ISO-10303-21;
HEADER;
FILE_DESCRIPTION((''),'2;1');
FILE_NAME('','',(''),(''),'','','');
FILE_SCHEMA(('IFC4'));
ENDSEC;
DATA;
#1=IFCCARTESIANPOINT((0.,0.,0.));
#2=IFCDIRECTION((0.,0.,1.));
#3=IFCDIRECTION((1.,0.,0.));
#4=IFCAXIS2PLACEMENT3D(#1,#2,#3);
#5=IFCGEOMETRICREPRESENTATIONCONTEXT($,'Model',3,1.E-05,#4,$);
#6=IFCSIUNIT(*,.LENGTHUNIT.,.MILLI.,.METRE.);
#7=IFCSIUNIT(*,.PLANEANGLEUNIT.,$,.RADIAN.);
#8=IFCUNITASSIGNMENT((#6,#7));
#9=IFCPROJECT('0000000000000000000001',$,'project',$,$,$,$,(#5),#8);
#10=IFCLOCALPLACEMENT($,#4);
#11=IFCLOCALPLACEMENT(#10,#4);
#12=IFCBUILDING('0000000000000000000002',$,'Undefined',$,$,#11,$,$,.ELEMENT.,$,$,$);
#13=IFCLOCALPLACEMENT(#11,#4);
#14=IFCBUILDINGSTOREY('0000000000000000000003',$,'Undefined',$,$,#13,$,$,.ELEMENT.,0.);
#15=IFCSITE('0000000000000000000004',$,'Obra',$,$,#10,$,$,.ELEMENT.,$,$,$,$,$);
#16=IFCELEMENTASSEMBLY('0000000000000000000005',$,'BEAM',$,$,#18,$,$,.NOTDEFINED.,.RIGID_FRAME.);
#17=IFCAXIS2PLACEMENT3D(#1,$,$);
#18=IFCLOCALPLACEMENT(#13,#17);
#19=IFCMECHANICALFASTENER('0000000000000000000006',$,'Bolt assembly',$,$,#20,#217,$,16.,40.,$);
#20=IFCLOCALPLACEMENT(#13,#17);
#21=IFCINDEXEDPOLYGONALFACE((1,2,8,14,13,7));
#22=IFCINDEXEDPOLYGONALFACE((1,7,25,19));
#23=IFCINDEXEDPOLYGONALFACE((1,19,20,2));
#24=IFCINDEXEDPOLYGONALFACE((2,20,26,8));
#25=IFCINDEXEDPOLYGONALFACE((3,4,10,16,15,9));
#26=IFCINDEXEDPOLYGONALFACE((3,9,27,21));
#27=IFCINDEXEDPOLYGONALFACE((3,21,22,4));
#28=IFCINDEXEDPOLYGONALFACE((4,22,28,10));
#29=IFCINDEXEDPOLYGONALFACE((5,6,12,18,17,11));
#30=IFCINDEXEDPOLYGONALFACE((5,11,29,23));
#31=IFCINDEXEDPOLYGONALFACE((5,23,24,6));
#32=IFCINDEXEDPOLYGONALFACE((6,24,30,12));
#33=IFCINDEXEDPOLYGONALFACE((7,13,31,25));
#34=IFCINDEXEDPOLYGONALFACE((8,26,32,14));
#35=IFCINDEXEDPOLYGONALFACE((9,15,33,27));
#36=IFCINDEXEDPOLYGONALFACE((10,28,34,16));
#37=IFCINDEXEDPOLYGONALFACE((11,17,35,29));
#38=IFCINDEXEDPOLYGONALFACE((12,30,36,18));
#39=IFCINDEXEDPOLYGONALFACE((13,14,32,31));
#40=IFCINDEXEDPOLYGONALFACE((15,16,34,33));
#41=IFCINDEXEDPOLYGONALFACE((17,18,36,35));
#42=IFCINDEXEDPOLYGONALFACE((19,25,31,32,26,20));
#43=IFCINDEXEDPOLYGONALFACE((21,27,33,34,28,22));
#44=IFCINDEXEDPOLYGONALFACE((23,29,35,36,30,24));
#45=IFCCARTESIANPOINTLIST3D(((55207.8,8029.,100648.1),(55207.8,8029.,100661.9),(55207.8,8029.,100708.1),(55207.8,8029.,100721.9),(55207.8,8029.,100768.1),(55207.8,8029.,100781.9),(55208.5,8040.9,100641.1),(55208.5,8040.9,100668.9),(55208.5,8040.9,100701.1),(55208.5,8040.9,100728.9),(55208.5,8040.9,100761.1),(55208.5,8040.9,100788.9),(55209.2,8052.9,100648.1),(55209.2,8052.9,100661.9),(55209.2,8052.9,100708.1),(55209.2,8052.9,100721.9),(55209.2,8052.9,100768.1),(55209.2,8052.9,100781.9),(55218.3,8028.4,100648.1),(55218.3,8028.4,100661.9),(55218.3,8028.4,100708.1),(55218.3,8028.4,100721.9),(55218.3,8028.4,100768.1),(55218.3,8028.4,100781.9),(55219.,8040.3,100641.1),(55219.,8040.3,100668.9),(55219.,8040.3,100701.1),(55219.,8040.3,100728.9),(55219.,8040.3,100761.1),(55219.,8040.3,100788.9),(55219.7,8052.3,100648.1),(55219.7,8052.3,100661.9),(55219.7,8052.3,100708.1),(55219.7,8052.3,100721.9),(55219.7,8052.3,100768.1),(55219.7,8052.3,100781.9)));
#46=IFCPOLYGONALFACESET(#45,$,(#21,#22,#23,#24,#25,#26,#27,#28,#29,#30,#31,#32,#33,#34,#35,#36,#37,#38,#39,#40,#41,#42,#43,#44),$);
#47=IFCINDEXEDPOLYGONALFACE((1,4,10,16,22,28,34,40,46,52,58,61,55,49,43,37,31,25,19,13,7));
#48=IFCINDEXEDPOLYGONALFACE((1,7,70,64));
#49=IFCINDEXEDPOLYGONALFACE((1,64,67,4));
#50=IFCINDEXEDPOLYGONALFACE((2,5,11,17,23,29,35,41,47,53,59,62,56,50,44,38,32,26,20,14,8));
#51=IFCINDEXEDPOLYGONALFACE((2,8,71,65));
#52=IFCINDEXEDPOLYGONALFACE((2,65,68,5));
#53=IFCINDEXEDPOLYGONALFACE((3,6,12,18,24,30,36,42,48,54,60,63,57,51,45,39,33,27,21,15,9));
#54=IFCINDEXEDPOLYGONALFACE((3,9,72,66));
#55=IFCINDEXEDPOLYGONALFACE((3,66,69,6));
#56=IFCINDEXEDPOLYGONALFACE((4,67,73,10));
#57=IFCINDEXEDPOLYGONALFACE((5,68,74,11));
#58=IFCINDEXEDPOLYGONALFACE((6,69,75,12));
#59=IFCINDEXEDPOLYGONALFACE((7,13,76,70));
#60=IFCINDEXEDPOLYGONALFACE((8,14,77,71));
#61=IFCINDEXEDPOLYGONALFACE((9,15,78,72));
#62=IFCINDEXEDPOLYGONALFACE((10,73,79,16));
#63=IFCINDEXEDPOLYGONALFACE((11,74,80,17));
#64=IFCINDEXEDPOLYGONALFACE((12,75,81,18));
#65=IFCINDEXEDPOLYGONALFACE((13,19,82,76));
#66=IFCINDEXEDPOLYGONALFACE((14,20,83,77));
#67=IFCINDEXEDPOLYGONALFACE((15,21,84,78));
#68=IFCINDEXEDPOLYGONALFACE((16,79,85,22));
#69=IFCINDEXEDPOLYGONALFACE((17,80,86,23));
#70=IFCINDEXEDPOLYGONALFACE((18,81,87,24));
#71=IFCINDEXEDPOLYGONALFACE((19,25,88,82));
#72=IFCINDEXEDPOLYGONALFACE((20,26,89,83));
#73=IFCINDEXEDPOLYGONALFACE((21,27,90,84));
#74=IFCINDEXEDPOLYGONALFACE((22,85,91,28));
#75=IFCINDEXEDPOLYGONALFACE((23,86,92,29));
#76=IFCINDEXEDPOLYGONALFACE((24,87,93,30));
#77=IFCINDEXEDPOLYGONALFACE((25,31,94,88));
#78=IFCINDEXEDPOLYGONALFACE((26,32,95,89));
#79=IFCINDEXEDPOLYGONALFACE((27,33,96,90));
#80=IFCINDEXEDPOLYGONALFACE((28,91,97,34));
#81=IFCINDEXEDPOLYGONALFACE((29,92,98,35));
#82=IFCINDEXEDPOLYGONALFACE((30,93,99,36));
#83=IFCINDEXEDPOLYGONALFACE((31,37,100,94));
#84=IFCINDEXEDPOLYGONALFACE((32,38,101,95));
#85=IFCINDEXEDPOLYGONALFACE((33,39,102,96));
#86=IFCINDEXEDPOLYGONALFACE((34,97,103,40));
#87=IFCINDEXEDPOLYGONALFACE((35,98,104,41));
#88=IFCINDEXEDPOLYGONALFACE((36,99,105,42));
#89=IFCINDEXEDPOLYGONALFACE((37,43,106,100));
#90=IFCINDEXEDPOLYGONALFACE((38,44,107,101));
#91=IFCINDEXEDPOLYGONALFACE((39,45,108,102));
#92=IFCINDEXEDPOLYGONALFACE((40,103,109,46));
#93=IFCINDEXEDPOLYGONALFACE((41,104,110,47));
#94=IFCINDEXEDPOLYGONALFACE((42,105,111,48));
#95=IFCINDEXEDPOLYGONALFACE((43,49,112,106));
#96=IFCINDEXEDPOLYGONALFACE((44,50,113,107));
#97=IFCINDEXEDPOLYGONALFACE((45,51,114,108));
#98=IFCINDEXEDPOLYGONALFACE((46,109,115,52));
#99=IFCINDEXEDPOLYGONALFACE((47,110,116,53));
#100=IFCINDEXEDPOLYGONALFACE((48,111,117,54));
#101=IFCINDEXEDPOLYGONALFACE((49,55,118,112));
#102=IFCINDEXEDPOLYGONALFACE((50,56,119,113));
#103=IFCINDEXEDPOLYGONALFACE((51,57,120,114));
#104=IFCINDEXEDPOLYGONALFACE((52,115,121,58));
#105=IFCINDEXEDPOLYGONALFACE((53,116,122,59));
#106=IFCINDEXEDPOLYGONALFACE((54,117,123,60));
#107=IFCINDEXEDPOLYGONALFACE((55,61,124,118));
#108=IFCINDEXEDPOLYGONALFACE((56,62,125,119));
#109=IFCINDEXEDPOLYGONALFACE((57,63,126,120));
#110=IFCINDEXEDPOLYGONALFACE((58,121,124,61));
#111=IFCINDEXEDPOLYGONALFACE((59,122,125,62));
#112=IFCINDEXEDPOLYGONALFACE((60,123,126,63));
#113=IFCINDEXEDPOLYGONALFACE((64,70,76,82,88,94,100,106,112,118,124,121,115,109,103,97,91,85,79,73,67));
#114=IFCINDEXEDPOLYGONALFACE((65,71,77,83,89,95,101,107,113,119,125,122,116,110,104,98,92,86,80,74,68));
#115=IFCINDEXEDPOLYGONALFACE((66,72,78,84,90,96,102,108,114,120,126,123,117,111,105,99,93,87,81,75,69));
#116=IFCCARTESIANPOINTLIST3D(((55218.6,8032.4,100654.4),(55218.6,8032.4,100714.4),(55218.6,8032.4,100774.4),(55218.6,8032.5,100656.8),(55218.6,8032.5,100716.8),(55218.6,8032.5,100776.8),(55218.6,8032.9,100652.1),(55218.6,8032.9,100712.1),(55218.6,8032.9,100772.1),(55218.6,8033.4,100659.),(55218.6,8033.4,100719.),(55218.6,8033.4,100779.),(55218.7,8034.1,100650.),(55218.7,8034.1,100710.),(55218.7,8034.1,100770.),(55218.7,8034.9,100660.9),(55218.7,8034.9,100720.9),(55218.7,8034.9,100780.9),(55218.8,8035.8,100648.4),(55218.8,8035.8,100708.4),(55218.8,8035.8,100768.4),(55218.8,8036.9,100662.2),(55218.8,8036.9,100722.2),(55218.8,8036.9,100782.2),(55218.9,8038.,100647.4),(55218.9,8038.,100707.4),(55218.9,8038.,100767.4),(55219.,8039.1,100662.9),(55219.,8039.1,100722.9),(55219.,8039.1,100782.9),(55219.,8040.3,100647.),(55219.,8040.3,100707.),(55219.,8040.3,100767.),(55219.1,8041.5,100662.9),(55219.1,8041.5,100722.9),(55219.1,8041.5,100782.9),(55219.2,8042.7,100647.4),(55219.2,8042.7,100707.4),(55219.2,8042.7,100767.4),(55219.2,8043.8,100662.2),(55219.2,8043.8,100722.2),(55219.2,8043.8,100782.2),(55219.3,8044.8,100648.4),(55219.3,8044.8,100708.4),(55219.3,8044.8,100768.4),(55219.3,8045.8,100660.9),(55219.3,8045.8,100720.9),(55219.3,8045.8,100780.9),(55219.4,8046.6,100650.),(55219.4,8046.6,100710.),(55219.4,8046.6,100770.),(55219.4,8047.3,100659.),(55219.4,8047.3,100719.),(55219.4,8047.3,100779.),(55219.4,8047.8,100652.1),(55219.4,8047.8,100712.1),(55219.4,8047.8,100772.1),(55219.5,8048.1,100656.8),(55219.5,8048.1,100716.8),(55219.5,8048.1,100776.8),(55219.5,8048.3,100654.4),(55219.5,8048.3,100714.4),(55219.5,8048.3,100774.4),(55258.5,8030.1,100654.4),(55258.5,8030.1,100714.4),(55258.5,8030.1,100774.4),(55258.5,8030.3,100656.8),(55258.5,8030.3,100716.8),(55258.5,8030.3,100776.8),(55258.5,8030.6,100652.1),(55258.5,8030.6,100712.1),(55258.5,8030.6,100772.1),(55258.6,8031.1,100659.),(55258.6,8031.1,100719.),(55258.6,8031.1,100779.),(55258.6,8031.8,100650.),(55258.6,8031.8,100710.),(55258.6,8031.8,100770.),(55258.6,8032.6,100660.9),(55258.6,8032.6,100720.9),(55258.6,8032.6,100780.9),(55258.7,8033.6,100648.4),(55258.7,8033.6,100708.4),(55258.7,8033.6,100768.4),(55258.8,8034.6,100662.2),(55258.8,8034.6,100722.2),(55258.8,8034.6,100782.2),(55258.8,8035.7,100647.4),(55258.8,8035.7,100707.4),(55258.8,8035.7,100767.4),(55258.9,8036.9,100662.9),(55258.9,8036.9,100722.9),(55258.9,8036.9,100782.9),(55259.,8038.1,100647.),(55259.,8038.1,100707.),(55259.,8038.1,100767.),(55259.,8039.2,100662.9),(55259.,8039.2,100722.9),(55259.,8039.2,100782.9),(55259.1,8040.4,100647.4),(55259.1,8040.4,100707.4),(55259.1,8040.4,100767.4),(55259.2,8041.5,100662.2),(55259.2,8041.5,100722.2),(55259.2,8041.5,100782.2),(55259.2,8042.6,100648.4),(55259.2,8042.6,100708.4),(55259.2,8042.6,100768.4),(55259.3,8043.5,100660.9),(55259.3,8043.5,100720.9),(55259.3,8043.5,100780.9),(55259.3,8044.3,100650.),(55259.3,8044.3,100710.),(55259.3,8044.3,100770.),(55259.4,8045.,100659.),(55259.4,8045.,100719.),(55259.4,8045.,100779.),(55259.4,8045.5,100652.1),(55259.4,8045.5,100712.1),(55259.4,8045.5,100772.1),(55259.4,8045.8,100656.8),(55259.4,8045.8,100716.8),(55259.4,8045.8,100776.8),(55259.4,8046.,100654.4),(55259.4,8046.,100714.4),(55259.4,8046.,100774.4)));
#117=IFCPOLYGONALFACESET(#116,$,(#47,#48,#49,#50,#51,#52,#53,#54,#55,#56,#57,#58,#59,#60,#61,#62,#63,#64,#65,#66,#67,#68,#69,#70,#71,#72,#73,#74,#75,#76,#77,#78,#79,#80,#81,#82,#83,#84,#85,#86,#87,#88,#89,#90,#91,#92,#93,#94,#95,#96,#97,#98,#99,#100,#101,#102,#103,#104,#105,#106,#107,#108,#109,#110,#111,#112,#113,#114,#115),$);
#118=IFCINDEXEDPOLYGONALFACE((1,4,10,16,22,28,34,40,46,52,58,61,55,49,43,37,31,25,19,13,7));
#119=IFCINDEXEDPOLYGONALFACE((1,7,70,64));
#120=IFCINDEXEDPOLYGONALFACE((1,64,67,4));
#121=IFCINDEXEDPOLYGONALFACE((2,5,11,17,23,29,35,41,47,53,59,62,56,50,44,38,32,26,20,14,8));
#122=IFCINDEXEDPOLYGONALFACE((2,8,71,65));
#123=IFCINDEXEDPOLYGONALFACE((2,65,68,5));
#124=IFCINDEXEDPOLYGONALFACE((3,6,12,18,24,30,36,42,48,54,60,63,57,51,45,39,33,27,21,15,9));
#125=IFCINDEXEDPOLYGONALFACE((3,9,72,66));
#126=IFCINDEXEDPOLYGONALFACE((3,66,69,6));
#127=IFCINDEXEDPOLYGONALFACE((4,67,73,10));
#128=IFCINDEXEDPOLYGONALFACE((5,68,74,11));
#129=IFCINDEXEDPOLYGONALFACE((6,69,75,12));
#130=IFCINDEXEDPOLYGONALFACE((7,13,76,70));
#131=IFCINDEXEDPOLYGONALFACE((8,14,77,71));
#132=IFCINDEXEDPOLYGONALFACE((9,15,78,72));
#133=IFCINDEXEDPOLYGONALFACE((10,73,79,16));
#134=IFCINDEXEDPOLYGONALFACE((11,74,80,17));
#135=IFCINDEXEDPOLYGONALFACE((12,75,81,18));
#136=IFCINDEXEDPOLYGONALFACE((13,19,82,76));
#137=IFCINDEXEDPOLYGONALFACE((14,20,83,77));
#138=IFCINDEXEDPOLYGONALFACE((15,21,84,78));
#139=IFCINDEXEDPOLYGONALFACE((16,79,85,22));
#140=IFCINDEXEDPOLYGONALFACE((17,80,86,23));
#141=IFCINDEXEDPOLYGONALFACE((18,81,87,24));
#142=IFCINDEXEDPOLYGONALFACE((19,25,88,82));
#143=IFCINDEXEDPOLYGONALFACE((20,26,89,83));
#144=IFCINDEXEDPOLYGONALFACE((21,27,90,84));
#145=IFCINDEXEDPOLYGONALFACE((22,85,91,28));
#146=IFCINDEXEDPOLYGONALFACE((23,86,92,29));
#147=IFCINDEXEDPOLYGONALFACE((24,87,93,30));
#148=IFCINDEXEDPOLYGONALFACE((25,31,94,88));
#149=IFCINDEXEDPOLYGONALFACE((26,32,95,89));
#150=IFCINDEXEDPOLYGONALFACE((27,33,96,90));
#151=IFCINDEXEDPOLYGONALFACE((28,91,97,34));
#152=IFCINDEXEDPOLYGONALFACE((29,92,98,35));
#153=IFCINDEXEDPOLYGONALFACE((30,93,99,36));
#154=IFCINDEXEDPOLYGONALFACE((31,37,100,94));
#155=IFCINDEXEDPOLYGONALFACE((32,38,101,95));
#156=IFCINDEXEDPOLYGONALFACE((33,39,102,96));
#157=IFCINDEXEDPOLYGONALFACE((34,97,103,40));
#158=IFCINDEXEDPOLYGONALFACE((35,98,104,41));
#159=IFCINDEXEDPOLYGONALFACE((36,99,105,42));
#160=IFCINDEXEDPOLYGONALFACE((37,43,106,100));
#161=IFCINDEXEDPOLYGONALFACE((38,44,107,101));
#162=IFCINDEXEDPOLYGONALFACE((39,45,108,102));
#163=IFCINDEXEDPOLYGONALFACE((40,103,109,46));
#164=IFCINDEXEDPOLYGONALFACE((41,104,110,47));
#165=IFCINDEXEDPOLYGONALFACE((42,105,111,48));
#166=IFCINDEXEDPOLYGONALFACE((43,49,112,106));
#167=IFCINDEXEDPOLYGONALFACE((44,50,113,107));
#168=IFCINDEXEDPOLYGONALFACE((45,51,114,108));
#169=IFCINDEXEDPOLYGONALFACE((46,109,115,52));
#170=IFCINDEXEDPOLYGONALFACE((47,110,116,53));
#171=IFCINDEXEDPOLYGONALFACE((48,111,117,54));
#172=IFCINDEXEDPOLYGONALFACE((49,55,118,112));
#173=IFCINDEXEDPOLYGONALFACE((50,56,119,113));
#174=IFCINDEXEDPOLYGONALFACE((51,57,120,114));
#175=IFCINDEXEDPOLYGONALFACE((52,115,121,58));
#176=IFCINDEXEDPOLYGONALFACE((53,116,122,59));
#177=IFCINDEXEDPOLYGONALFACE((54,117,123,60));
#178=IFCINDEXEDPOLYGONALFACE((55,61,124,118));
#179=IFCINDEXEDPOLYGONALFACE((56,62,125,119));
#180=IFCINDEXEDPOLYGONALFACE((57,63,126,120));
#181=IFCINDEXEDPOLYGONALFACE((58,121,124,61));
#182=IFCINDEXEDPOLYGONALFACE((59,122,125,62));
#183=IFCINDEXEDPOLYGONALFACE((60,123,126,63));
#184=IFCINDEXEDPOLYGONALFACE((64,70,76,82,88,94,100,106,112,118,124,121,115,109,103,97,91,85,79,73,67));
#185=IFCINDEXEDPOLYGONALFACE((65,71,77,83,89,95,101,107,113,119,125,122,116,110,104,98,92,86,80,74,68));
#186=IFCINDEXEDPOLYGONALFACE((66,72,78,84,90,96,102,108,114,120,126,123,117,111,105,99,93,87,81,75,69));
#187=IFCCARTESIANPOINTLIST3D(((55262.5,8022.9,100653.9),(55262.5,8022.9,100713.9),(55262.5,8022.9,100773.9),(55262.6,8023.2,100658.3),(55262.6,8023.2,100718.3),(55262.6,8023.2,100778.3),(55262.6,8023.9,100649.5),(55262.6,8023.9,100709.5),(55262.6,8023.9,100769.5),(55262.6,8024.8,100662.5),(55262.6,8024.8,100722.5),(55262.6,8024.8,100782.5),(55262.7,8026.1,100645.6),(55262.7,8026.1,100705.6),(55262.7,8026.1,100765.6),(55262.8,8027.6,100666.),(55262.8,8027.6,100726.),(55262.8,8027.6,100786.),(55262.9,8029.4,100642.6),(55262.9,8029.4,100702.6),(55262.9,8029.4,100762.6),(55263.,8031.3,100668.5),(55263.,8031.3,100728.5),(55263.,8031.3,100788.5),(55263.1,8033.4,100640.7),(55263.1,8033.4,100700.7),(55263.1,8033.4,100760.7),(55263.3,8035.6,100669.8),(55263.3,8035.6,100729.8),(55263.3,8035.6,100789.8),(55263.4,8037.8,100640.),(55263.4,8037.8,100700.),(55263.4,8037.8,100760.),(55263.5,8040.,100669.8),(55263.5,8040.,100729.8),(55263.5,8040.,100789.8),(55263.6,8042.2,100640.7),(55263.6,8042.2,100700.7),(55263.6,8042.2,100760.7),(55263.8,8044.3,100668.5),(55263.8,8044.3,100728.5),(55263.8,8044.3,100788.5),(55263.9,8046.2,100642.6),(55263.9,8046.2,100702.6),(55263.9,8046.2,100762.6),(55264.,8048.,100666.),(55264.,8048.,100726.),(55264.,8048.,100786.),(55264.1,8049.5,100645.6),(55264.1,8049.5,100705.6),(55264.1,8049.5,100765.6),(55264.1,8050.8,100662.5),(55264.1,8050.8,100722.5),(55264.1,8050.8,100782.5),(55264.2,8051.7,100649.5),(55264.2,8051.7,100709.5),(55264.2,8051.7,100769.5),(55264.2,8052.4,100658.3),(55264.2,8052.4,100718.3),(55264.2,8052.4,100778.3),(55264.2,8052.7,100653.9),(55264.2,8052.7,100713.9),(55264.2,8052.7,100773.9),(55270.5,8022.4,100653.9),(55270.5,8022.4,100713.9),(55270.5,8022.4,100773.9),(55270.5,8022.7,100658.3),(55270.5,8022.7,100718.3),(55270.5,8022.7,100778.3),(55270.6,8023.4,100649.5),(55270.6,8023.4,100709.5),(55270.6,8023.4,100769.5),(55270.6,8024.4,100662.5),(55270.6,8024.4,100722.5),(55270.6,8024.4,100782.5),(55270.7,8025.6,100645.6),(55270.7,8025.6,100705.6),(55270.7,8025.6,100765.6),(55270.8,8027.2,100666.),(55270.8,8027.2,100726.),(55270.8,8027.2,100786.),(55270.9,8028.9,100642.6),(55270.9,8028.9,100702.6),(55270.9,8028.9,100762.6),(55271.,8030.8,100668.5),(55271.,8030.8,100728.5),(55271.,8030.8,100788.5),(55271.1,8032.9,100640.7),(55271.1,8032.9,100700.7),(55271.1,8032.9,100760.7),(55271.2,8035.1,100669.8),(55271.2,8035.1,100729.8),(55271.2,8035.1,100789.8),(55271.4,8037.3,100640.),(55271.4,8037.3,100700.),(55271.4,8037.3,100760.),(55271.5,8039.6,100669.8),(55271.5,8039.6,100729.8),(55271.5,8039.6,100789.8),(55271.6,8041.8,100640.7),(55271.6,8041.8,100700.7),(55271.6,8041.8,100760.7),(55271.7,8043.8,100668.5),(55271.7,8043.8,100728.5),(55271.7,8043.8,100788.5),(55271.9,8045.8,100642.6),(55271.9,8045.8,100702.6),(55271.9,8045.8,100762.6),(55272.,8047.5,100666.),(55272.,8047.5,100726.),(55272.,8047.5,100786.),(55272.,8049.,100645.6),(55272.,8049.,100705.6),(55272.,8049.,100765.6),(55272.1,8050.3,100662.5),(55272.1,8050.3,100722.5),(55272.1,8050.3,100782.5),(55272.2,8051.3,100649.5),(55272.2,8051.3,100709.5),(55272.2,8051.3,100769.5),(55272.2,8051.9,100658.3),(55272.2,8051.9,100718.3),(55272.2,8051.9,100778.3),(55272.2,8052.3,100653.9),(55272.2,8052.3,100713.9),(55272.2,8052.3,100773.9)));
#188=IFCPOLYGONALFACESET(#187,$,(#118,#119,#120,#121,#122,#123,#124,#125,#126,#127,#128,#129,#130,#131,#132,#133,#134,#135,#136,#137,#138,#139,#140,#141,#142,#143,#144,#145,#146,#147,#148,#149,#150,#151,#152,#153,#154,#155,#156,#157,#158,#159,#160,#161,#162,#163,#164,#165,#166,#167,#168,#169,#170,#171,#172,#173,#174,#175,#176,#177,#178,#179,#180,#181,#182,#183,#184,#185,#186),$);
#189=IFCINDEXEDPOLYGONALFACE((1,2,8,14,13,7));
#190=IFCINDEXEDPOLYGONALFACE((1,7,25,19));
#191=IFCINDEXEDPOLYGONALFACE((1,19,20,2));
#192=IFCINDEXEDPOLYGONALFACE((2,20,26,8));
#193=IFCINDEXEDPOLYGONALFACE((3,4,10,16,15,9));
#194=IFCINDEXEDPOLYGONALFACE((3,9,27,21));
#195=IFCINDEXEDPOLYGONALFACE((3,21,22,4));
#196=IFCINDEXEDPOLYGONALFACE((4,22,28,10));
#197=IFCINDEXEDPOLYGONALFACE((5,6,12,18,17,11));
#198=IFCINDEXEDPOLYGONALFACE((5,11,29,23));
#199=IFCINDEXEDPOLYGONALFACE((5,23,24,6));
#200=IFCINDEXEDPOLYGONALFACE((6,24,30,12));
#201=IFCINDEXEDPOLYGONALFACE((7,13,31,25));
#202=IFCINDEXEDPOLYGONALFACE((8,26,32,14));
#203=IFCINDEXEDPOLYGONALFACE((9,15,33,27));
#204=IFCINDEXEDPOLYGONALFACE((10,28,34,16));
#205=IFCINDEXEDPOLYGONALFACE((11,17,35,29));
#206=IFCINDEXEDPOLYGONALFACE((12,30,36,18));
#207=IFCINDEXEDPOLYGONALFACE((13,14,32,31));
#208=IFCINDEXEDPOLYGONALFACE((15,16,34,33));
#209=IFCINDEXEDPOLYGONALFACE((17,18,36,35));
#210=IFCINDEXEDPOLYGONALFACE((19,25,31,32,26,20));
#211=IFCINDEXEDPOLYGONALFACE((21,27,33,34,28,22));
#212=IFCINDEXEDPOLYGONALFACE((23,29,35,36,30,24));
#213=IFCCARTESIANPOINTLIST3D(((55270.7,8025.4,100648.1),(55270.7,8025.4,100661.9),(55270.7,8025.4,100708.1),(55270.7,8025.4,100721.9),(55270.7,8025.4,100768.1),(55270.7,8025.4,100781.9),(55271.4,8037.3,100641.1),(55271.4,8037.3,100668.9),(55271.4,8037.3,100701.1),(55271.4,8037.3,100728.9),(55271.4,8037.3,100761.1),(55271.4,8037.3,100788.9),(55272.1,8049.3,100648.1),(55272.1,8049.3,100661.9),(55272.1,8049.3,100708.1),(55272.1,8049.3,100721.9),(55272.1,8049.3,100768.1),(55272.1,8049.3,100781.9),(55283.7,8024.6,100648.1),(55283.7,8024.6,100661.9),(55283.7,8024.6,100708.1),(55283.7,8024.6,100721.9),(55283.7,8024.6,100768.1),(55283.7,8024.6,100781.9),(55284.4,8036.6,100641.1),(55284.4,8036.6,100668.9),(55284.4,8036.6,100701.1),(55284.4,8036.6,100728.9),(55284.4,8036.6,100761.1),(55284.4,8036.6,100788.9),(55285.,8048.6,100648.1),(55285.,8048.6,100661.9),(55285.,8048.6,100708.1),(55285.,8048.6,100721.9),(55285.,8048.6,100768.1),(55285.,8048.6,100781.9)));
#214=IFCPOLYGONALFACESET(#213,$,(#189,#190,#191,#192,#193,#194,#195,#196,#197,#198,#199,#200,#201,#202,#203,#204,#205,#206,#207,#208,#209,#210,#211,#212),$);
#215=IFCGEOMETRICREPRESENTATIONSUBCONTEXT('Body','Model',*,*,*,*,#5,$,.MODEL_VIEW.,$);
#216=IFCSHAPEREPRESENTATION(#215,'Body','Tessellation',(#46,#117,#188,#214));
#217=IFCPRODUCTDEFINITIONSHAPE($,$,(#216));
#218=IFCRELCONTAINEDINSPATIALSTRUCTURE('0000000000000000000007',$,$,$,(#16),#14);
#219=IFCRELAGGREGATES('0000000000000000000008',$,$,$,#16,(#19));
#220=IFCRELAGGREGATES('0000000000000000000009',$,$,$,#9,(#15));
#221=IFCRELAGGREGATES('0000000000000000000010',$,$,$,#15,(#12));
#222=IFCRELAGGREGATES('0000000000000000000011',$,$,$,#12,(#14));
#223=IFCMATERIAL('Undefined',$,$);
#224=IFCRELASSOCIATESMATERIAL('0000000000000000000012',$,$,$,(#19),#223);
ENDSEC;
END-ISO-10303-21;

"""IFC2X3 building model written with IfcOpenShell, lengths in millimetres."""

from ifc_helpers import new_model, si_unit, frame, origin_with_axes, origin_2d_with_axis, place, context, subcontext, project, spatial, polyline, circle, outline, extrude, source, transform, mapped, material, element, aggregate, save


model = new_model("IFC2X3")

# Units and contexts
model_context = context("Model", 3, precision=1e-05, world=origin_with_axes())
body_context = subcontext(model_context, "Body", "Model", "MODEL_VIEW")
ifc_project = project(units=[si_unit("LENGTHUNIT", "METRE", prefix="MILLI"), si_unit("PLANEANGLEUNIT", "RADIAN")], contexts=[model_context])

# Site, building, storey
site_placement = place(None, origin_with_axes())
site = spatial("IfcSite", under=ifc_project, at=site_placement, Name="Obra", CompositionType="ELEMENT")
building_placement = place(site_placement, origin_with_axes())
building = spatial("IfcBuilding", under=site, at=building_placement, Name="Undefined", CompositionType="ELEMENT")
storey_placement = place(building_placement, origin_with_axes())
storey = spatial("IfcBuildingStorey", under=building, at=storey_placement, Name="Undefined", CompositionType="ELEMENT", Elevation=0.0)

# Shared definitions
ifc_material_1 = material(Name="Undefined")

# Element assembly
assembly_1_placement = place(storey_placement, origin_with_axes())
assembly_1 = element("IfcElementAssembly", 1, at=assembly_1_placement, inside=storey, Name="BEAM", AssemblyPlace="NOTDEFINED", PredefinedType="RIGID_FRAME")

# Shared definitions
shared_shape_1 = source(origin_with_axes(), body_context, "Body", "SweptSolid", [
    extrude(outline(polyline([(13.9, 0.0), (6.9, 12.0), (-6.9, 12.0), (-13.9, 0.0), (-6.9, -12.0), (6.9, -12.0), (13.9, 0.0)])), frame((0.0, -19.7, 0.0), z_axis=(0.0, 1.0, 0.0), x_axis=(1.0, 0.0, 0.0)), (0.0, 0.0, 1.0), 10.6),
    extrude(circle(Radius=8.0, at=origin_2d_with_axis()), frame((0.0, -9.1, 0.0), z_axis=(0.0, 1.0, 0.0), x_axis=(1.0, 0.0, 0.0)), (0.0, 0.0, 1.0), 40.0),
    extrude(circle(Radius=15.0, at=origin_2d_with_axis()), frame((0.0, 35.3, 0.0), z_axis=(0.0, 1.0, 0.0), x_axis=(1.0, 0.0, 0.0)), (0.0, 0.0, 1.0), 8.0),
    extrude(outline(polyline([(13.9, 0.0), (6.9, 12.0), (-6.9, 12.0), (-13.9, 0.0), (-6.9, -12.0), (6.9, -12.0), (13.9, 0.0)])), frame((0.0, 43.3, 0.0), z_axis=(0.0, 1.0, 0.0), x_axis=(1.0, 0.0, 0.0)), (0.0, 0.0, 1.0), 13.0),
])

# Mechanical fastener
mechanical_fastener_1_placement = place(assembly_1_placement, frame((55231.0, 8089.7, 100835.0), z_axis=(-0.05711, -0.998368, 0.0), x_axis=(0.0, 0.0, -1.0)))
mechanical_fastener_1 = element("IfcMechanicalFastener", 2, at=mechanical_fastener_1_placement, material=ifc_material_1, Name="Bolt assembly", NominalDiameter=16.0, NominalLength=40.0, context=body_context, shape_type="MappedRepresentation", body=[
    mapped(shared_shape_1, transform((60.0, 0.0, 50.0))),
    mapped(shared_shape_1, transform((120.0, 0.0, 50.0))),
    mapped(shared_shape_1, transform((180.0, 0.0, 50.0))),
])
aggregate(assembly_1, [mechanical_fastener_1])

save(model, "model.ifc")
